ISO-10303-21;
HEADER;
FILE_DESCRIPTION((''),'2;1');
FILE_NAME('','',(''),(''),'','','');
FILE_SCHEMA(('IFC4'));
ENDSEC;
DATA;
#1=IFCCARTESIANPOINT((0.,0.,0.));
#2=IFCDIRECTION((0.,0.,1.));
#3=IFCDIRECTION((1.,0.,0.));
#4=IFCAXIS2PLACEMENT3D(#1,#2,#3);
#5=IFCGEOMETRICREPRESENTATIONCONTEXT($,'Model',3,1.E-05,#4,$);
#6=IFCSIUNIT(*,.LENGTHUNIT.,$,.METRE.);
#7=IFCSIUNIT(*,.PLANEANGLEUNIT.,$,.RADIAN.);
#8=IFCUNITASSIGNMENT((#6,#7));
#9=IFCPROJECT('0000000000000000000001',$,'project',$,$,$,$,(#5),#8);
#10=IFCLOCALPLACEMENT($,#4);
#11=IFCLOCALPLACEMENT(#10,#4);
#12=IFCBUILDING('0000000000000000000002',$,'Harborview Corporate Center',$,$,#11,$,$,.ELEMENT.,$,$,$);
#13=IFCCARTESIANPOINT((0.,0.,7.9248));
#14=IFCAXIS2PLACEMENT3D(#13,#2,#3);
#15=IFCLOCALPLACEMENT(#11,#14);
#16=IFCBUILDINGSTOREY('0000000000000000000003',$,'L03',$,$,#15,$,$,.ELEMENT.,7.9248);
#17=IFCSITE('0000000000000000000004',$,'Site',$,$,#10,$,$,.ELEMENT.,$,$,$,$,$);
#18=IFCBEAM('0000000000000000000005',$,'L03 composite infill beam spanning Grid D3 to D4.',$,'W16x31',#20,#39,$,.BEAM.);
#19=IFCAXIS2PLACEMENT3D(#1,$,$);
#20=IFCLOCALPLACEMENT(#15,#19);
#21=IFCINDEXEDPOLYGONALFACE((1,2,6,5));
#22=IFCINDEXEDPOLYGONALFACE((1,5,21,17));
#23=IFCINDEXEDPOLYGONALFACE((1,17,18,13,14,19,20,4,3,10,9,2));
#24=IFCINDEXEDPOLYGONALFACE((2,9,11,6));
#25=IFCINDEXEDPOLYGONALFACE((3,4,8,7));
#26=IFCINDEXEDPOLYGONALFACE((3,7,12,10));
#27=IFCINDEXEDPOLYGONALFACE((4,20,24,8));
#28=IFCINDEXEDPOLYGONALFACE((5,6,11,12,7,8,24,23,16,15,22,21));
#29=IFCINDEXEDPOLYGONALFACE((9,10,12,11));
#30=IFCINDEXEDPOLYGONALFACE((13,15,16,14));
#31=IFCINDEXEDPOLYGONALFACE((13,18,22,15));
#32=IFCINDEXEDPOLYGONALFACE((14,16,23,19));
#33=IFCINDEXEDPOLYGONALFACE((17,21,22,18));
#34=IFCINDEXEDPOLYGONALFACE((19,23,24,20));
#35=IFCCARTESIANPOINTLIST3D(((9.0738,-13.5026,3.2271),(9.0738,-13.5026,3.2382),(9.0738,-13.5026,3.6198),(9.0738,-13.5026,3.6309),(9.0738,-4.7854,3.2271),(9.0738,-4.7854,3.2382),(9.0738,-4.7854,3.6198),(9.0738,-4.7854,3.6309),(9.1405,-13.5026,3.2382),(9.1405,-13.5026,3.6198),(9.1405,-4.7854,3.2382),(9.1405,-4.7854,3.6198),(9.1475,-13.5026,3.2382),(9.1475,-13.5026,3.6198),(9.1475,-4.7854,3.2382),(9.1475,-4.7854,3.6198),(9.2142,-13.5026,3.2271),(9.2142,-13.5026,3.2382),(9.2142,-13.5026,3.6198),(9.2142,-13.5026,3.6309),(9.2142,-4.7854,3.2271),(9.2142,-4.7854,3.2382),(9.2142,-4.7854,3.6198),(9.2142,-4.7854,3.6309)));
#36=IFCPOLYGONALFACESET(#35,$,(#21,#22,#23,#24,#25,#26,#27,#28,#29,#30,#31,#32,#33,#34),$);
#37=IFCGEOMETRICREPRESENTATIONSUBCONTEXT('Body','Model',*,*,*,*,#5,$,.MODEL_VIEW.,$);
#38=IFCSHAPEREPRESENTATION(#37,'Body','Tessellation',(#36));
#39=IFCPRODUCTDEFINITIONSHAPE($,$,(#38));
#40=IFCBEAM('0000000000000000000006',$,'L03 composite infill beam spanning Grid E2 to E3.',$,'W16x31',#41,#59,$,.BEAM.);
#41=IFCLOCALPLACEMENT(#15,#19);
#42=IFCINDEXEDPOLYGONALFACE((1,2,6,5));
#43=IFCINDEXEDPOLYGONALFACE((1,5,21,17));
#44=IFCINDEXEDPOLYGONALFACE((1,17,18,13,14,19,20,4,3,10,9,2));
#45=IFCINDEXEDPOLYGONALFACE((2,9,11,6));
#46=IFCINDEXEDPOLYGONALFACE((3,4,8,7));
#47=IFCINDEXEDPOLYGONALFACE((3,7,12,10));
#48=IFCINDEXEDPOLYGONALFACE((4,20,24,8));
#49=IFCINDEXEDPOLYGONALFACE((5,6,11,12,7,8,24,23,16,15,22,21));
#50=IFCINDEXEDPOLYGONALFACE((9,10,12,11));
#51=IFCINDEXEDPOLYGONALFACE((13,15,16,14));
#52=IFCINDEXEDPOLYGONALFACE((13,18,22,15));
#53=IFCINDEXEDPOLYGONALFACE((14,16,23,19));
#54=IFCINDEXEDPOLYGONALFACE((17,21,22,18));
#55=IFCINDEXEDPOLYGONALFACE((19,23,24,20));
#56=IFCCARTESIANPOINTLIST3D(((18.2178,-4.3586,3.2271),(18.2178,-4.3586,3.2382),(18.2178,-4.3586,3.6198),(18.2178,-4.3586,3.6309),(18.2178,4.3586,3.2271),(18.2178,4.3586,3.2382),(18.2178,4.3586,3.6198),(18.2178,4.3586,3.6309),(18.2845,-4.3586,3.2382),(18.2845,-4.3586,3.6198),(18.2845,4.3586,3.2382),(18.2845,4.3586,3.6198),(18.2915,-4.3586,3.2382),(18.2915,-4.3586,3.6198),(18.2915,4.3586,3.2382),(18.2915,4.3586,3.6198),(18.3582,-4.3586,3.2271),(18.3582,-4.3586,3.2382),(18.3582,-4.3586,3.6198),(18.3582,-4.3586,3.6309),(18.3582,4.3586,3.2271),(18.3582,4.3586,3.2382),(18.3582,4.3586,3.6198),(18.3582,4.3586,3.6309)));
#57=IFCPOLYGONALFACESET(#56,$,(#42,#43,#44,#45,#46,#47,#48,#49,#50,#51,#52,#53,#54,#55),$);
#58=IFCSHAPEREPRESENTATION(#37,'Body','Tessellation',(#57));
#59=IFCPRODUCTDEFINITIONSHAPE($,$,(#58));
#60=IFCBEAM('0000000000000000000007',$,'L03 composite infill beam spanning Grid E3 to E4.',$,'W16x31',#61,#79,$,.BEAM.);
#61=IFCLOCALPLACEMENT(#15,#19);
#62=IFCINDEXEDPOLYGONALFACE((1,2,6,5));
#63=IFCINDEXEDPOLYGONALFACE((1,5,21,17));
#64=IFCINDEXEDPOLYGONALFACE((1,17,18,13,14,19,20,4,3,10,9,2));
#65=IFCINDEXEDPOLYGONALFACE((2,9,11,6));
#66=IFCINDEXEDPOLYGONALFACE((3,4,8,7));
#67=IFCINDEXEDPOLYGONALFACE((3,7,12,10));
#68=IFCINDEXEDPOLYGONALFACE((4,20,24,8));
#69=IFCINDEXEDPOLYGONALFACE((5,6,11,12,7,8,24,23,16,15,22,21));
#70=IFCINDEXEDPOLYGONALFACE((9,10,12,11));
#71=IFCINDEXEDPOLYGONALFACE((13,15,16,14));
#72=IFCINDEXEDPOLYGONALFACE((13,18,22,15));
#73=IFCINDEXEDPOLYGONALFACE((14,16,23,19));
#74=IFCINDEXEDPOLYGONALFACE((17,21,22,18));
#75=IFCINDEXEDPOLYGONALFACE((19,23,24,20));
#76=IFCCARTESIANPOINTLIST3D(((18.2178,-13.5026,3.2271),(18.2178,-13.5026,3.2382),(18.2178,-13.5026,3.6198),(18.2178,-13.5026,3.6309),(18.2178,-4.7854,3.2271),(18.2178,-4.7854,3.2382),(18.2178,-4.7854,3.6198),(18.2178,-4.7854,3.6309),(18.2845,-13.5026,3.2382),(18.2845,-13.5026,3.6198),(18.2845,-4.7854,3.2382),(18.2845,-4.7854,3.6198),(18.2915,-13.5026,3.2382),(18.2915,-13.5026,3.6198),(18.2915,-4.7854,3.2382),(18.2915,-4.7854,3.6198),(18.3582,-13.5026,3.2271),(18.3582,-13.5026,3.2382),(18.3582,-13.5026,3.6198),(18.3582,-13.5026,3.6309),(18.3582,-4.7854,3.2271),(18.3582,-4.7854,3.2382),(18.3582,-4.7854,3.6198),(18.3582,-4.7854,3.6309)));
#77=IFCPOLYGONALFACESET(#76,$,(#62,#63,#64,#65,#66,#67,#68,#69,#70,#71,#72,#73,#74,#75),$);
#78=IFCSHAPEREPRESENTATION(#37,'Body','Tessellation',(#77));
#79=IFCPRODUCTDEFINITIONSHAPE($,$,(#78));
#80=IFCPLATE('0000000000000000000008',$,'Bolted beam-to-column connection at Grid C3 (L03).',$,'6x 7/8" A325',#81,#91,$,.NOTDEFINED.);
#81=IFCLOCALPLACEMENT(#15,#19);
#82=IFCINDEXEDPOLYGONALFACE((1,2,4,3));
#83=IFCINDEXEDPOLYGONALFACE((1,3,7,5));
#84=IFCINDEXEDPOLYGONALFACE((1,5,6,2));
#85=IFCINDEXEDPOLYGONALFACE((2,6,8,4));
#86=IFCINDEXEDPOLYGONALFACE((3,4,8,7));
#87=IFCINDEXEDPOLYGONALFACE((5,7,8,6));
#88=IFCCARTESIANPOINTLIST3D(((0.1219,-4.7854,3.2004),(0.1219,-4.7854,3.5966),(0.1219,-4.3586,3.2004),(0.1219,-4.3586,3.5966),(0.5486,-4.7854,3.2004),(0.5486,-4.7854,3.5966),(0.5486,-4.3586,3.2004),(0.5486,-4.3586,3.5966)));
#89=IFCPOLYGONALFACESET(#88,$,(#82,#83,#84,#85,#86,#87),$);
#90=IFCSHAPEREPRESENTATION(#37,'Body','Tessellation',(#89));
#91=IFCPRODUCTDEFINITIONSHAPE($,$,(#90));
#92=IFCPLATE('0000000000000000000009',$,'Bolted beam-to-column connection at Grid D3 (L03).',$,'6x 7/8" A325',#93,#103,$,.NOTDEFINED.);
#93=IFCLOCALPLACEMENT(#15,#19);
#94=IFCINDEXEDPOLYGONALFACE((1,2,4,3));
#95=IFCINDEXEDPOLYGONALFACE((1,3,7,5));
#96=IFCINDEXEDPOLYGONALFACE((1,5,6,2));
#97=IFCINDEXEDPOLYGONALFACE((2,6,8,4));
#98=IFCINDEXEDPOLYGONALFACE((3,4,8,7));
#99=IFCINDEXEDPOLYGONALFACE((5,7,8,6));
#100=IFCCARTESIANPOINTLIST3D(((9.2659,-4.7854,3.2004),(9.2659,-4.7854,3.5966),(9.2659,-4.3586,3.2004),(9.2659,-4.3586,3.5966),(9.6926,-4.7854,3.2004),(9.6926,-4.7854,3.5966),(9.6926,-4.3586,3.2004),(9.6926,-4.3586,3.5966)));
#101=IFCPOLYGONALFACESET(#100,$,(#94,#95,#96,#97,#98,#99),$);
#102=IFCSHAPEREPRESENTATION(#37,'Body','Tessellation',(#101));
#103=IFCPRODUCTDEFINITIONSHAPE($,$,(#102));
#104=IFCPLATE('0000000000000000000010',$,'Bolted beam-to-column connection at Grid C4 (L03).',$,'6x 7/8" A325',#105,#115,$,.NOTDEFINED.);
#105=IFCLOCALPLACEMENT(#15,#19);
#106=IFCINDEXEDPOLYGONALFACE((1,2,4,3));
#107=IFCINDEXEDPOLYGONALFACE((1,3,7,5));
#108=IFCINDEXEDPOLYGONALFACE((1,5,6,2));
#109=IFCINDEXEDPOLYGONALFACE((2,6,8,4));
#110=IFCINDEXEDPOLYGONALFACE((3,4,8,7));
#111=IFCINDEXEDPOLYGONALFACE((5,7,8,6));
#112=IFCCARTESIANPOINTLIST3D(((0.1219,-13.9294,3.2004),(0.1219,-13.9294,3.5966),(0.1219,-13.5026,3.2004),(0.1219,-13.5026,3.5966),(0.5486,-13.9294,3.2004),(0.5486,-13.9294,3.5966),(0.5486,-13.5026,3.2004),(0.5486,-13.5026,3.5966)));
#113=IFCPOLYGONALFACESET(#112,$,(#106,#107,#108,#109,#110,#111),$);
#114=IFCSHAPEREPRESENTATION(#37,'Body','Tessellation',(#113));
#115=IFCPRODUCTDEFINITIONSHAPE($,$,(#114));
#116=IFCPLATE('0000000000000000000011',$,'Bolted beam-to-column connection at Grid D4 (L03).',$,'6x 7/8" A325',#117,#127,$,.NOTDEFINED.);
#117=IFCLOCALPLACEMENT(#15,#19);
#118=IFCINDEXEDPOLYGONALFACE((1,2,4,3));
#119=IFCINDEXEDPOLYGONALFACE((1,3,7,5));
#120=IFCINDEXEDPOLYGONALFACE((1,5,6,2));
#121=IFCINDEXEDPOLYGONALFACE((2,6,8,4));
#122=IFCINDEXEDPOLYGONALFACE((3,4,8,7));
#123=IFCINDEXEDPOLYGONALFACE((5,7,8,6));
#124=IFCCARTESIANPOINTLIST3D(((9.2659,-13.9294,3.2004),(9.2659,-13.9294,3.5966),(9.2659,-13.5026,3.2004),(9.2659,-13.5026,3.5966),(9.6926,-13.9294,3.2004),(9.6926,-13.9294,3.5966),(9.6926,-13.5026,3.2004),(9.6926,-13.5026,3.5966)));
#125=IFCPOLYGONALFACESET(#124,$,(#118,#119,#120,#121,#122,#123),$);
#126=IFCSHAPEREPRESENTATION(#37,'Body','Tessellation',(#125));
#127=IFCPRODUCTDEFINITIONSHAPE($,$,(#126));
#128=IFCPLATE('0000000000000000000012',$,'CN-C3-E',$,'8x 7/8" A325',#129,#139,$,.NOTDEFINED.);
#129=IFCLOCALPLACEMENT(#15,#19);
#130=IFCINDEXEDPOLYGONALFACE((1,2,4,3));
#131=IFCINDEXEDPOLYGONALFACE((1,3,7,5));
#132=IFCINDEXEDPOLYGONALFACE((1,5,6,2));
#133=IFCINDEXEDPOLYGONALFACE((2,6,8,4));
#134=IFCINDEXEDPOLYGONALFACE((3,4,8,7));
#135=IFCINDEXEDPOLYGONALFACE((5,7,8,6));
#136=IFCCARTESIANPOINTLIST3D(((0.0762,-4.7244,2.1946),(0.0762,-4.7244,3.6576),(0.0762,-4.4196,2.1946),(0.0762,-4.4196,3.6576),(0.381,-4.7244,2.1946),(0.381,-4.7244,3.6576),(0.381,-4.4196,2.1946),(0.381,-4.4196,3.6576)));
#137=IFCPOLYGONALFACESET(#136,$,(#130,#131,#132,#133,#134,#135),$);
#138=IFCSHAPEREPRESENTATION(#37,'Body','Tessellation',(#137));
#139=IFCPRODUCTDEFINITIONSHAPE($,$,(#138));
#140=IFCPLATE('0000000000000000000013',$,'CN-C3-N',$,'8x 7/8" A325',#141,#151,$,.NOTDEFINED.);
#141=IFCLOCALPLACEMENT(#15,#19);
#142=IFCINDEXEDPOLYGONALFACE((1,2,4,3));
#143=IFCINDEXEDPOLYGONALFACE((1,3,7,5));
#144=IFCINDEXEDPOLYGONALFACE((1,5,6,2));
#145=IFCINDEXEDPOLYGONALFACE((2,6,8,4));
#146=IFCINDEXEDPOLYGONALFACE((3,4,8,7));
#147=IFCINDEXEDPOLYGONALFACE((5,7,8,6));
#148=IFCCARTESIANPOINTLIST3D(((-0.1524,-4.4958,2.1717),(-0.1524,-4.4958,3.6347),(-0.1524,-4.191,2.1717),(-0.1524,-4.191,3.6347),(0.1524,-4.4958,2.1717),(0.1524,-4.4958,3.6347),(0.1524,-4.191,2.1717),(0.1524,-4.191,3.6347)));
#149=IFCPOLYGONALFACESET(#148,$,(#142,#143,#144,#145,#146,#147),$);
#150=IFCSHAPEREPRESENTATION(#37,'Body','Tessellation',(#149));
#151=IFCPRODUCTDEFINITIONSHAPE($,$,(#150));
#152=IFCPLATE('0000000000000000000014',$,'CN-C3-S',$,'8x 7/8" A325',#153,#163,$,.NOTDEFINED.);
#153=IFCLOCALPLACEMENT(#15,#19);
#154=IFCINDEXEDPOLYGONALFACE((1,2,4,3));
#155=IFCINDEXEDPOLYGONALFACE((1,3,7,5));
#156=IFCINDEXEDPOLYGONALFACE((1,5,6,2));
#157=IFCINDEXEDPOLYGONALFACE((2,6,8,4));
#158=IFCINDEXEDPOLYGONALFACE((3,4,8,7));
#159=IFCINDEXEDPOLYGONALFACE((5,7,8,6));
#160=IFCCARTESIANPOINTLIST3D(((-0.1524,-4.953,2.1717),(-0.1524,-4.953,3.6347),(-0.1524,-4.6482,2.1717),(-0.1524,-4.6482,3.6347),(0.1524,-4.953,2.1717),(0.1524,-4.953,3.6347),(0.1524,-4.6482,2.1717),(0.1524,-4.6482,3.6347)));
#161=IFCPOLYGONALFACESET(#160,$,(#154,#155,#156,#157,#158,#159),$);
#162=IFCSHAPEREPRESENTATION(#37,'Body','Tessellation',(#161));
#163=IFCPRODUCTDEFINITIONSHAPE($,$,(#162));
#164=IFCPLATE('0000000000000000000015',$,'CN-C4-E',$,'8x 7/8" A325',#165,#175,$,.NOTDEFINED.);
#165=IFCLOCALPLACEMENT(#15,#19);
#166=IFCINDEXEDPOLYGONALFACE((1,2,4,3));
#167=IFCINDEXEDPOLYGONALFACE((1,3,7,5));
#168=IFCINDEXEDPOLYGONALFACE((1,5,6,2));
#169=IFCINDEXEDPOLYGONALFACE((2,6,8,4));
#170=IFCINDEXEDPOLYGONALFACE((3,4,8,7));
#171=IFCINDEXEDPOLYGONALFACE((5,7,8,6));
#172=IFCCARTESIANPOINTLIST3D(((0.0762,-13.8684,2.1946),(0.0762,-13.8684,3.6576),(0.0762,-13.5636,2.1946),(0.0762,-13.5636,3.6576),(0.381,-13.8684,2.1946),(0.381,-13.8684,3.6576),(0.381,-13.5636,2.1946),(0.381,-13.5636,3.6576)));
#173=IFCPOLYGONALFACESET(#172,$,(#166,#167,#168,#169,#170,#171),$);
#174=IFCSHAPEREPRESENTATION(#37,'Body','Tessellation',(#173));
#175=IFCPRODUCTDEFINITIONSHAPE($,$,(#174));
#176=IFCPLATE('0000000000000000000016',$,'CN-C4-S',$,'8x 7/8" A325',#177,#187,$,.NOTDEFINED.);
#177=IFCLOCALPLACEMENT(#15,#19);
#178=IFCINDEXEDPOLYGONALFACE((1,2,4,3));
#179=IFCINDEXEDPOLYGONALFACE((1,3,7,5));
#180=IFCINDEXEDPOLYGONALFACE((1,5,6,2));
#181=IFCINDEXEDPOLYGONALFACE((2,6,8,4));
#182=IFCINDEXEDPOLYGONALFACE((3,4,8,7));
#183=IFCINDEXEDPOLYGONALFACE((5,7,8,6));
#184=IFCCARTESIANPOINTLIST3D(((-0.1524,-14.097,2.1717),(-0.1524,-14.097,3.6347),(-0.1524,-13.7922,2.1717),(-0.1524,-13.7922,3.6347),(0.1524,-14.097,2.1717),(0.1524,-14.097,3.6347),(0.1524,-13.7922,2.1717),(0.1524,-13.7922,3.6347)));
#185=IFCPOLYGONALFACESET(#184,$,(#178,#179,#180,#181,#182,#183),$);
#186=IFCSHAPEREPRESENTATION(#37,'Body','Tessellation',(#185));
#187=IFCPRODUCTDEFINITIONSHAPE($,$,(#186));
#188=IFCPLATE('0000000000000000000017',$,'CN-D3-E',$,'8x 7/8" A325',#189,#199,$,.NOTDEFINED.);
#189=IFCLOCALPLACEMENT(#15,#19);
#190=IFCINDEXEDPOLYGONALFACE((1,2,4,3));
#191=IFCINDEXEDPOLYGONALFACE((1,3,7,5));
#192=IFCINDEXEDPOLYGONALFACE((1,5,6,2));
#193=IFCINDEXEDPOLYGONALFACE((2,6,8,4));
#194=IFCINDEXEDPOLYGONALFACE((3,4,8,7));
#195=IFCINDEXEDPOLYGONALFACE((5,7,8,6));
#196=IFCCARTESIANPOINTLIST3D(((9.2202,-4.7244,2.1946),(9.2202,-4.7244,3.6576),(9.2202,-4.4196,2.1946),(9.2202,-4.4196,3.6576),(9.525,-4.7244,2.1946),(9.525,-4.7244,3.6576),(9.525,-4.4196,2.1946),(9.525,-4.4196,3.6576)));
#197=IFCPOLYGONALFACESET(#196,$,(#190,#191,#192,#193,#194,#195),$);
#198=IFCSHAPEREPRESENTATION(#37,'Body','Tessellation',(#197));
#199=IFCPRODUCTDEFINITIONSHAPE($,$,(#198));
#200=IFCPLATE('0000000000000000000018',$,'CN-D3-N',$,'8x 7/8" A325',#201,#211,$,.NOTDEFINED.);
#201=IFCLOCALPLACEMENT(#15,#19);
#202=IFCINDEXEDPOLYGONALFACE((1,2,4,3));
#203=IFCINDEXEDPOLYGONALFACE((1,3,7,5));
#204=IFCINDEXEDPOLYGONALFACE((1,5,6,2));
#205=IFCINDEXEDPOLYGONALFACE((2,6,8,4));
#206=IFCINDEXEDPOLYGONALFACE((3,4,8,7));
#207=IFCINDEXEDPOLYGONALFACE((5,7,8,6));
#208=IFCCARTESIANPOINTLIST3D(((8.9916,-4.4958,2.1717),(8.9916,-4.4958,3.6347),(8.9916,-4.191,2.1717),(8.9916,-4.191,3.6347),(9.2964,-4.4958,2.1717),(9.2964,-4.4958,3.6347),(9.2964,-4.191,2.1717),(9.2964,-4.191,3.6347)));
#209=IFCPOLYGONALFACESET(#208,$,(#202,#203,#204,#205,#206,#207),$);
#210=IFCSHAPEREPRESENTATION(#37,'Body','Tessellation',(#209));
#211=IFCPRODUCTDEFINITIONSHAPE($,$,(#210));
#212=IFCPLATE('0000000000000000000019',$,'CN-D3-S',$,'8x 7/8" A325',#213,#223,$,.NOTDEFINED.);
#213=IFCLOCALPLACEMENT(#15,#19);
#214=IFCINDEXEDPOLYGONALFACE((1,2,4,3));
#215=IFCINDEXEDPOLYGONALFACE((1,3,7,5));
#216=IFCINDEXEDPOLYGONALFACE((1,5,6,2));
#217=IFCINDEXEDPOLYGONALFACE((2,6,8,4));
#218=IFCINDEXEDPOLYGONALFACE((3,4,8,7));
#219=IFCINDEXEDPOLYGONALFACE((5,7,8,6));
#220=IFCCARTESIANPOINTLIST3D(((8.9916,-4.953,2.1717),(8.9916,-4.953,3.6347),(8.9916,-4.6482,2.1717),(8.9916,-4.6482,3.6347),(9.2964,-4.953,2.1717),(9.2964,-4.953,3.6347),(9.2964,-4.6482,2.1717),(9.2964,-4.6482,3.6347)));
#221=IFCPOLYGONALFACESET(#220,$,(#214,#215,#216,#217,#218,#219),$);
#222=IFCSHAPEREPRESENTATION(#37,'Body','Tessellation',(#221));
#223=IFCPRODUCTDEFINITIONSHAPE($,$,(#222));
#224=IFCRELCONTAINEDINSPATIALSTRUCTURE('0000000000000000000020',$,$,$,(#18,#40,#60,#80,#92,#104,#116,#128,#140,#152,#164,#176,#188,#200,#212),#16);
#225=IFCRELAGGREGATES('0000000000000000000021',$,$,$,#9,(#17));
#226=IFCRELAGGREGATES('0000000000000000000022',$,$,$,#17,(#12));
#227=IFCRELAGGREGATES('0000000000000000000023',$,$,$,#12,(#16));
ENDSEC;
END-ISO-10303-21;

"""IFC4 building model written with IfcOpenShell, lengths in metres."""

from ifc_helpers import new_model, si_unit, frame, origin_with_axes, place, context, subcontext, project, spatial, rectangle, i_section, extrude, element, save


model = new_model("IFC4")

# Units and contexts
model_context = context("Model", 3, precision=1e-05, world=origin_with_axes())
body_context = subcontext(model_context, "Body", "Model", "MODEL_VIEW")
ifc_project = project(units=[si_unit("LENGTHUNIT", "METRE"), si_unit("PLANEANGLEUNIT", "RADIAN")], contexts=[model_context])

# Site, building, storey
site_placement = place(None, origin_with_axes())
site = spatial("IfcSite", under=ifc_project, at=site_placement, Name="Site", CompositionType="ELEMENT")
building_placement = place(site_placement, origin_with_axes())
building = spatial("IfcBuilding", under=site, at=building_placement, Name="Harborview Corporate Center", CompositionType="ELEMENT")
storey_placement = place(building_placement, frame((0.0, 0.0, 7.9248), z_axis=(0.0, 0.0, 1.0), x_axis=(1.0, 0.0, 0.0)))
storey = spatial("IfcBuildingStorey", under=building, at=storey_placement, Name="L03", CompositionType="ELEMENT", Elevation=7.9248)

# Beams
beam_1_placement = place(storey_placement, frame((9.144, -13.5026, 3.429), z_axis=(0.0, 1.0, 0.0), x_axis=(-1.0, 0.0, 0.0)))
element("IfcBeam", 1, at=beam_1_placement, inside=storey, Name="L03 composite infill beam spanning Grid D3 to D4.", ObjectType="W16x31", PredefinedType="BEAM", context=body_context, shape_type="SweptSolid", body=[
    extrude(i_section(OverallWidth=0.1405, OverallDepth=0.4039, WebThickness=0.007, FlangeThickness=0.0112), origin_with_axes(), (0.0, 0.0, 1.0), 8.7173),
])
beam_2_placement = place(storey_placement, frame((18.288, -4.3586, 3.429), z_axis=(0.0, 1.0, 0.0), x_axis=(-1.0, 0.0, 0.0)))
element("IfcBeam", 2, at=beam_2_placement, inside=storey, Name="L03 composite infill beam spanning Grid E2 to E3.", ObjectType="W16x31", PredefinedType="BEAM", context=body_context, shape_type="SweptSolid", body=[
    extrude(i_section(OverallWidth=0.1405, OverallDepth=0.4039, WebThickness=0.007, FlangeThickness=0.0112), origin_with_axes(), (0.0, 0.0, 1.0), 8.7173),
])
beam_3_placement = place(storey_placement, frame((18.288, -13.5026, 3.429), z_axis=(0.0, 1.0, 0.0), x_axis=(-1.0, 0.0, 0.0)))
element("IfcBeam", 3, at=beam_3_placement, inside=storey, Name="L03 composite infill beam spanning Grid E3 to E4.", ObjectType="W16x31", PredefinedType="BEAM", context=body_context, shape_type="SweptSolid", body=[
    extrude(i_section(OverallWidth=0.1405, OverallDepth=0.4039, WebThickness=0.007, FlangeThickness=0.0112), origin_with_axes(), (0.0, 0.0, 1.0), 8.7173),
])

# Plates
plate_1_placement = place(storey_placement, frame((0.3353, -4.572, 3.2004), z_axis=(0.0, 0.0, 1.0), x_axis=(1.0, 0.0, 0.0)))
element("IfcPlate", 4, at=plate_1_placement, inside=storey, Name="Bolted beam-to-column connection at Grid C3 (L03).", ObjectType="6x 7/8\" A325", PredefinedType="NOTDEFINED", context=body_context, shape_type="SweptSolid", body=[
    extrude(rectangle(XDim=0.4267, YDim=0.4267), origin_with_axes(), (0.0, 0.0, 1.0), 0.3962),
])
plate_2_placement = place(storey_placement, frame((9.4793, -4.572, 3.2004), z_axis=(0.0, 0.0, 1.0), x_axis=(1.0, 0.0, 0.0)))
element("IfcPlate", 5, at=plate_2_placement, inside=storey, Name="Bolted beam-to-column connection at Grid D3 (L03).", ObjectType="6x 7/8\" A325", PredefinedType="NOTDEFINED", context=body_context, shape_type="SweptSolid", body=[
    extrude(rectangle(XDim=0.4267, YDim=0.4267), origin_with_axes(), (0.0, 0.0, 1.0), 0.3962),
])
plate_3_placement = place(storey_placement, frame((0.3353, -13.716, 3.2004), z_axis=(0.0, 0.0, 1.0), x_axis=(1.0, 0.0, 0.0)))
element("IfcPlate", 6, at=plate_3_placement, inside=storey, Name="Bolted beam-to-column connection at Grid C4 (L03).", ObjectType="6x 7/8\" A325", PredefinedType="NOTDEFINED", context=body_context, shape_type="SweptSolid", body=[
    extrude(rectangle(XDim=0.4267, YDim=0.4267), origin_with_axes(), (0.0, 0.0, 1.0), 0.3962),
])
plate_4_placement = place(storey_placement, frame((9.4793, -13.716, 3.2004), z_axis=(0.0, 0.0, 1.0), x_axis=(1.0, 0.0, 0.0)))
element("IfcPlate", 7, at=plate_4_placement, inside=storey, Name="Bolted beam-to-column connection at Grid D4 (L03).", ObjectType="6x 7/8\" A325", PredefinedType="NOTDEFINED", context=body_context, shape_type="SweptSolid", body=[
    extrude(rectangle(XDim=0.4267, YDim=0.4267), origin_with_axes(), (0.0, 0.0, 1.0), 0.3962),
])
for number, where, z_axis, x_axis, name in (
    (8, (0.2286, -4.572, 2.1946), (0.0, 0.0, 1.0), (1.0, 0.0, 0.0), "CN-C3-E"),
    (9, (0.0, -4.3434, 2.1717), (0.0, 0.0, 1.0), (1.0, 0.0, 0.0), "CN-C3-N"),
    (10, (0.0, -4.8006, 2.1717), (0.0, 0.0, 1.0), (1.0, 0.0, 0.0), "CN-C3-S"),
    (11, (0.2286, -13.716, 2.1946), (0.0, 0.0, 1.0), (1.0, 0.0, 0.0), "CN-C4-E"),
    (12, (0.0, -13.9446, 2.1717), (0.0, 0.0, 1.0), (1.0, 0.0, 0.0), "CN-C4-S"),
):
    element("IfcPlate", number, at=place(storey_placement, frame(where, z_axis=z_axis, x_axis=x_axis)), inside=storey, Name=name, ObjectType="8x 7/8\" A325", PredefinedType="NOTDEFINED", context=body_context, shape_type="SweptSolid", body=[
        extrude(rectangle(XDim=0.3048, YDim=0.3048), origin_with_axes(), (0.0, 0.0, 1.0), 1.463),
    ])
for number, where, z_axis, x_axis, name in (
    (13, (9.3726, -4.572, 2.1946), (0.0, 0.0, 1.0), (1.0, 0.0, 0.0), "CN-D3-E"),
    (14, (9.144, -4.3434, 2.1717), (0.0, 0.0, 1.0), (1.0, 0.0, 0.0), "CN-D3-N"),
    (15, (9.144, -4.8006, 2.1717), (0.0, 0.0, 1.0), (1.0, 0.0, 0.0), "CN-D3-S"),
):
    element("IfcPlate", number, at=place(storey_placement, frame(where, z_axis=z_axis, x_axis=x_axis)), inside=storey, Name=name, ObjectType="8x 7/8\" A325", PredefinedType="NOTDEFINED", context=body_context, shape_type="SweptSolid", body=[
        extrude(rectangle(XDim=0.3048, YDim=0.3048), origin_with_axes(), (0.0, 0.0, 1.0), 1.463),
    ])

save(model, "model.ifc")
